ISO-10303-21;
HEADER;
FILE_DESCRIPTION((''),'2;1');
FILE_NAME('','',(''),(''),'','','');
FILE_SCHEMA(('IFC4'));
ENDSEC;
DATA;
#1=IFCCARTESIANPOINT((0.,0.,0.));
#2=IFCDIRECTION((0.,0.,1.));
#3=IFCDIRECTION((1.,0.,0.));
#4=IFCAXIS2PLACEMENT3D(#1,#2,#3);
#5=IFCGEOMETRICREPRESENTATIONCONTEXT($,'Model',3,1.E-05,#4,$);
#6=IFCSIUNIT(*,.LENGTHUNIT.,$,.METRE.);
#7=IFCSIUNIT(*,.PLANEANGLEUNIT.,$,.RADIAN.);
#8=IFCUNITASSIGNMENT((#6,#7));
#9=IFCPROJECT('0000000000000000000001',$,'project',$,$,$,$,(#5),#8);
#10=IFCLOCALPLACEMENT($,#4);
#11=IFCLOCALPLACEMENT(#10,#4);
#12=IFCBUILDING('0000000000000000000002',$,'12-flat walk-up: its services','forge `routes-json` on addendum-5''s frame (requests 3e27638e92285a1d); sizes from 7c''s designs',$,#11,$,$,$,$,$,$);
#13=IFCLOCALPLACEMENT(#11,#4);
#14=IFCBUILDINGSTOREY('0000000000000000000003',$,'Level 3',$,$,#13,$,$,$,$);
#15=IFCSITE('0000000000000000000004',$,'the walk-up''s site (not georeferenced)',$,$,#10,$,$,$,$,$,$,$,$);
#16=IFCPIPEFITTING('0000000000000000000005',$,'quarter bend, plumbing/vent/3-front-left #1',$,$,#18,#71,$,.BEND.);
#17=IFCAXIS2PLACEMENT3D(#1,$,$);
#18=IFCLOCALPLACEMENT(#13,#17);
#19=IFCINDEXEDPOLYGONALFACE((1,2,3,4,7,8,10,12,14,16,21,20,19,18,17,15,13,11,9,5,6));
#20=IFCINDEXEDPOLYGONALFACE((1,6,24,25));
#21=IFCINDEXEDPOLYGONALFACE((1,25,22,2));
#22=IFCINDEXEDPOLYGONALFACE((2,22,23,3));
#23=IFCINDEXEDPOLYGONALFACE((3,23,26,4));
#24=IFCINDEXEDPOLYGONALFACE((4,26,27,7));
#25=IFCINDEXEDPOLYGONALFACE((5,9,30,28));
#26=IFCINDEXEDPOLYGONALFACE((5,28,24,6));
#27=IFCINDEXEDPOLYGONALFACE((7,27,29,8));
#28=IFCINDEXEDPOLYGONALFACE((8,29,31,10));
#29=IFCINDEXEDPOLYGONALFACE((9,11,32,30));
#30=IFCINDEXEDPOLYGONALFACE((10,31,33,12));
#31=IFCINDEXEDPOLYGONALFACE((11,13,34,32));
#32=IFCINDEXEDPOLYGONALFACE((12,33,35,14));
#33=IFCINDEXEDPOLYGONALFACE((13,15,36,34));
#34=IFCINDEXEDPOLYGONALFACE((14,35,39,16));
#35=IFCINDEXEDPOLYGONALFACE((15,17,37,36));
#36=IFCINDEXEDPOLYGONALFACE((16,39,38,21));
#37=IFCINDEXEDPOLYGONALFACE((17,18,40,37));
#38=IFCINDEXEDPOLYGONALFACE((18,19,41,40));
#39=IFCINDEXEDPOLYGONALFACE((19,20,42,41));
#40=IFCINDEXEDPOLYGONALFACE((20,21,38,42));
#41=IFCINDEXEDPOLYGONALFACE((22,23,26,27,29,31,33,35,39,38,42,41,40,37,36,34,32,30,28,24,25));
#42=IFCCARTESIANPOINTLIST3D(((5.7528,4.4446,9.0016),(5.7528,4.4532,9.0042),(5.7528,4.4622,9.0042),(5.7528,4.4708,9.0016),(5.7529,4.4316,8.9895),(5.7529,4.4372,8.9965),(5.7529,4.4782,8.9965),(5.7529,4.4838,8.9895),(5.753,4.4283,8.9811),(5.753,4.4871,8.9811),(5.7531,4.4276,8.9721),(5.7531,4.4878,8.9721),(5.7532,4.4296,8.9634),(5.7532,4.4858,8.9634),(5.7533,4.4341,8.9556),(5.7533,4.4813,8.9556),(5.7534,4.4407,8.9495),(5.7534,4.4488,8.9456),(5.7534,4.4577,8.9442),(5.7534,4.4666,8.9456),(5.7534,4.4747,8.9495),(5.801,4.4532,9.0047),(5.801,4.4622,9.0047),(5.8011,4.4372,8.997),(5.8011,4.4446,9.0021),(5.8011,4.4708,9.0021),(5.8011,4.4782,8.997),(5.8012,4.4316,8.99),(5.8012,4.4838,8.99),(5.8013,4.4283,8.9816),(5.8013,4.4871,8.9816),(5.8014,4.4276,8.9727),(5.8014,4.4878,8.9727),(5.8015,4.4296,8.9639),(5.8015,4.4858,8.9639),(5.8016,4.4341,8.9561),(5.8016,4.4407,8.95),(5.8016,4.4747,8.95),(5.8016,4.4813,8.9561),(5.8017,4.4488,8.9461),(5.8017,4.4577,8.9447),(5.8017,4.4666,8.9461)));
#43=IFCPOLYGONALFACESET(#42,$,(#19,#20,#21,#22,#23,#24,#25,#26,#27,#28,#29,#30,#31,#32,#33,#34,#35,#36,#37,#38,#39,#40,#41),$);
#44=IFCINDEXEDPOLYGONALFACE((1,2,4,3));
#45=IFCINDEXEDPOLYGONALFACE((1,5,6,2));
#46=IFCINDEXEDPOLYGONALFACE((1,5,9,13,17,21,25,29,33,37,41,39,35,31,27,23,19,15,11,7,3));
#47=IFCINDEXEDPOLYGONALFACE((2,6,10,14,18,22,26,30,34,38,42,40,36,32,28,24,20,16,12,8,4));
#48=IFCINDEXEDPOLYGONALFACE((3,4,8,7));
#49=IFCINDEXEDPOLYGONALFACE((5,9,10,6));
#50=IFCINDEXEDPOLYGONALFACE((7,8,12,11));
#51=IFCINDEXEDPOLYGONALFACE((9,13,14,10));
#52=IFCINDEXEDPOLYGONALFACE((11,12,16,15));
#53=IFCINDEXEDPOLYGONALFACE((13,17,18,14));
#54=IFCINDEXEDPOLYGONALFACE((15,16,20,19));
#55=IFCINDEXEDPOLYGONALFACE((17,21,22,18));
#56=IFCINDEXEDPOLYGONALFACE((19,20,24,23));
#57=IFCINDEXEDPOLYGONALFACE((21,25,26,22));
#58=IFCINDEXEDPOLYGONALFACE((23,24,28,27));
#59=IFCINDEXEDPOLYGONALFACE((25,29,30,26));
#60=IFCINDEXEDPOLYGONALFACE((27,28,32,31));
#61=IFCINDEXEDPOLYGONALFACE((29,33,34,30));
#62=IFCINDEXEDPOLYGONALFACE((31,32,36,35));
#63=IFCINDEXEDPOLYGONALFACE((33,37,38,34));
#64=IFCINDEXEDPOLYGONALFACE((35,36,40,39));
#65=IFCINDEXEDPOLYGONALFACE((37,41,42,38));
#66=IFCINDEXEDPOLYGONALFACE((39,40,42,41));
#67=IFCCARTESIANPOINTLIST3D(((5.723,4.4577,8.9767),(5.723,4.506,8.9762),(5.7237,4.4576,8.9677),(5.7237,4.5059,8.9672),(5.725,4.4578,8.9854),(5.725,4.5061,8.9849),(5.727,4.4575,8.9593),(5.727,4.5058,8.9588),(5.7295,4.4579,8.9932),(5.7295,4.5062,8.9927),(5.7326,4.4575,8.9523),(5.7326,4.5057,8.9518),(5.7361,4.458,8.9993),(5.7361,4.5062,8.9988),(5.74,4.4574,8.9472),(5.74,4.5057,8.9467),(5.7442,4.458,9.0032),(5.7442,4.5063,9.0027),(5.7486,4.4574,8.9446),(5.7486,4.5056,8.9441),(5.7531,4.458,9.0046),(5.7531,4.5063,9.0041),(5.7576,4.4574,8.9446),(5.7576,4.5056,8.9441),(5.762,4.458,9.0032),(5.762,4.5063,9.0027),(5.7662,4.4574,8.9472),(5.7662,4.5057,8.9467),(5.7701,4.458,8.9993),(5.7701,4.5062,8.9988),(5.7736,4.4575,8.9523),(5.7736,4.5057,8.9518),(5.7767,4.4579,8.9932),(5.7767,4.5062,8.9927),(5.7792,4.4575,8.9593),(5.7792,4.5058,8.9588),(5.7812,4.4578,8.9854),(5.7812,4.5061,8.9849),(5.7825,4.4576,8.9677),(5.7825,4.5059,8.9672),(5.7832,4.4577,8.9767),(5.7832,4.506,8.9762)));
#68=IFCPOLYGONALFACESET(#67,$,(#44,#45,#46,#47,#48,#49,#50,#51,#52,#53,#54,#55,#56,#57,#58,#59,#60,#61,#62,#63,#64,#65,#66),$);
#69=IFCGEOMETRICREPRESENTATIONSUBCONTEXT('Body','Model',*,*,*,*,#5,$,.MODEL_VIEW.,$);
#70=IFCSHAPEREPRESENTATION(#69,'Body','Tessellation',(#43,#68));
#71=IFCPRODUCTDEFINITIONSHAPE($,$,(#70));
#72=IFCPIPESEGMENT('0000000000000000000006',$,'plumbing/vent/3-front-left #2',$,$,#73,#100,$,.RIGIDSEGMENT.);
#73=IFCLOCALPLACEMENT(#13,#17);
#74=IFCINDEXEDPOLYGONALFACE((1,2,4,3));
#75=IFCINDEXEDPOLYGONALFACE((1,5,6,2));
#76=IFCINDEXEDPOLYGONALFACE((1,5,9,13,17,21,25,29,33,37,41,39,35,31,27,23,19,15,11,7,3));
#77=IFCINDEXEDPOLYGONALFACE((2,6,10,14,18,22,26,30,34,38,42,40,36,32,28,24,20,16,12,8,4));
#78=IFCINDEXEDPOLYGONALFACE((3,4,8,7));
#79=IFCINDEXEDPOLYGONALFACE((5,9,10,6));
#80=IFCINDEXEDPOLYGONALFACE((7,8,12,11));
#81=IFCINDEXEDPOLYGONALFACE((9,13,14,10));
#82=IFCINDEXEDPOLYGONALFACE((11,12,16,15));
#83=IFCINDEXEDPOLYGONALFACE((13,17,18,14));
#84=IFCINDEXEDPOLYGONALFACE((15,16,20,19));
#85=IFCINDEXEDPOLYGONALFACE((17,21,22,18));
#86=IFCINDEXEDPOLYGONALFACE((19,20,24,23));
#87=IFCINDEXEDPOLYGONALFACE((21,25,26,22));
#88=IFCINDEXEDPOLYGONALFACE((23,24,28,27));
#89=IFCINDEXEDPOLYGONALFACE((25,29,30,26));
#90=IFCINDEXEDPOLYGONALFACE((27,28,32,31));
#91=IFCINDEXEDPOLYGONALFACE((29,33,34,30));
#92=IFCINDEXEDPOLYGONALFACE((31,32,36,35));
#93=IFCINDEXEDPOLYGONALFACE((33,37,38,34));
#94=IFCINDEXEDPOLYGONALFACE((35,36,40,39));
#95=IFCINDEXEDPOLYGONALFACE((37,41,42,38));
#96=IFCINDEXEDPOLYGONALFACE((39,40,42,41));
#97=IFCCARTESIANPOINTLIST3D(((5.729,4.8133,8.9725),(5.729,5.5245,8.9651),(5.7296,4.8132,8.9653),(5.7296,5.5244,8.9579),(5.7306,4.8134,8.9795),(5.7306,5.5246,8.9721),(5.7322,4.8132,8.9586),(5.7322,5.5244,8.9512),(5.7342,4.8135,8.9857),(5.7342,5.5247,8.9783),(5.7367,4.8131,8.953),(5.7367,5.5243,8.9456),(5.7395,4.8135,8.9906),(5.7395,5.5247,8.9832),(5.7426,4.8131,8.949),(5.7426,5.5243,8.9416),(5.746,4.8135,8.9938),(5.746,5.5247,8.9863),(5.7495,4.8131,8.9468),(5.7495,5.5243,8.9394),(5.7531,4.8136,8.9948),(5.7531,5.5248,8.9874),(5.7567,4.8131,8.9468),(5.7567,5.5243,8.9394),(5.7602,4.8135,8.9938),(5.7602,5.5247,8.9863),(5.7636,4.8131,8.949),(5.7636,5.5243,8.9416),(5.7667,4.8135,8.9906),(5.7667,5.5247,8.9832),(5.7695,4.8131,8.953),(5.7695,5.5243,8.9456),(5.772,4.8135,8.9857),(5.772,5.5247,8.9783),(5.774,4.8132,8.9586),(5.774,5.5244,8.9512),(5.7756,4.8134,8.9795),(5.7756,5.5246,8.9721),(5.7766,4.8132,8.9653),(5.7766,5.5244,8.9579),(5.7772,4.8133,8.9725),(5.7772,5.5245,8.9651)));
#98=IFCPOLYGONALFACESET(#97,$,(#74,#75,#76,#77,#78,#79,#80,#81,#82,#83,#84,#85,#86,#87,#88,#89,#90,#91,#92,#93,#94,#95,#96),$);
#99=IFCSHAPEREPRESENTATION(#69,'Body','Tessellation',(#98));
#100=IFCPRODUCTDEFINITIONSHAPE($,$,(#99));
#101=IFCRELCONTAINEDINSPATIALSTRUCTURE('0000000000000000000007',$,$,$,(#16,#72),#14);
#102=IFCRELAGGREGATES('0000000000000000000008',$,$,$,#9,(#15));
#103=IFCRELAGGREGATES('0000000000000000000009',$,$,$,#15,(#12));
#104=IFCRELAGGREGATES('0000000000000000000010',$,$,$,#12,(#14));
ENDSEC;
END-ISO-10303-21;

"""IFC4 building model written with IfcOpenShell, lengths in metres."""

from ifc_helpers import new_model, entity, si_unit, frame, origin_with_axes, place, context, subcontext, project, spatial, element, save


model = new_model("IFC4")

# Units and contexts
model_context = context("Model", 3, precision=1e-05, world=origin_with_axes())
body_context = subcontext(model_context, "Body", "Model", "MODEL_VIEW")
ifc_project = project(units=[si_unit("LENGTHUNIT", "METRE"), si_unit("PLANEANGLEUNIT", "RADIAN")], contexts=[model_context])

# Site, building, storey
site_placement = place(None, origin_with_axes())
site = spatial("IfcSite", under=ifc_project, at=site_placement, Name="the walk-up's site (not georeferenced)")
building_placement = place(site_placement, origin_with_axes())
building = spatial("IfcBuilding", under=site, at=building_placement, Name="12-flat walk-up: its services", Description="forge `routes-json` on addendum-5's frame (requests 3e27638e92285a1d); sizes from 7c's designs")
storey_placement = place(building_placement, origin_with_axes())
storey = spatial("IfcBuildingStorey", under=building, at=storey_placement, Name="Level 3")

# Pipe fitting
pipe_fitting_1_placement = place(storey_placement, frame((5.8014, 4.4577, 8.9749), z_axis=(0.0, 0.0, 1.0), x_axis=(1.0, 0.0, 0.0)))
element("IfcPipeFitting", 1, at=pipe_fitting_1_placement, inside=storey, Name="quarter bend, plumbing/vent/3-front-left #1", PredefinedType="BEND", context=body_context, shape_type="AdvancedSweptSolid", body=[
    entity("IfcSweptDiskSolid", entity("IfcPolyline", [entity("IfcCartesianPoint", [0.0, 0.0, 0.0]), entity("IfcCartesianPoint", [-0.0483, 0.0, -0.0005])]), 0.0302),
    entity("IfcSweptDiskSolid", entity("IfcPolyline", [entity("IfcCartesianPoint", [-0.0483, 0.0, -0.0005]), entity("IfcCartesianPoint", [-0.0483, 0.0483, -0.001])]), 0.0302),
])

# Pipe segment
pipe_segment_1_placement = place(storey_placement, frame((5.7531, 4.8133, 8.9707), z_axis=(0.0, 0.0, 1.0), x_axis=(1.0, 0.0, 0.0)))
element("IfcPipeSegment", 2, at=pipe_segment_1_placement, inside=storey, Name="plumbing/vent/3-front-left #2", PredefinedType="RIGIDSEGMENT", context=body_context, shape_type="AdvancedSweptSolid", body=[
    entity("IfcSweptDiskSolid", entity("IfcPolyline", [entity("IfcCartesianPoint", [0.0, 0.0, 0.0]), entity("IfcCartesianPoint", [0.0, 0.7112, -0.0074])]), 0.0241),
])

save(model, "model.ifc")
